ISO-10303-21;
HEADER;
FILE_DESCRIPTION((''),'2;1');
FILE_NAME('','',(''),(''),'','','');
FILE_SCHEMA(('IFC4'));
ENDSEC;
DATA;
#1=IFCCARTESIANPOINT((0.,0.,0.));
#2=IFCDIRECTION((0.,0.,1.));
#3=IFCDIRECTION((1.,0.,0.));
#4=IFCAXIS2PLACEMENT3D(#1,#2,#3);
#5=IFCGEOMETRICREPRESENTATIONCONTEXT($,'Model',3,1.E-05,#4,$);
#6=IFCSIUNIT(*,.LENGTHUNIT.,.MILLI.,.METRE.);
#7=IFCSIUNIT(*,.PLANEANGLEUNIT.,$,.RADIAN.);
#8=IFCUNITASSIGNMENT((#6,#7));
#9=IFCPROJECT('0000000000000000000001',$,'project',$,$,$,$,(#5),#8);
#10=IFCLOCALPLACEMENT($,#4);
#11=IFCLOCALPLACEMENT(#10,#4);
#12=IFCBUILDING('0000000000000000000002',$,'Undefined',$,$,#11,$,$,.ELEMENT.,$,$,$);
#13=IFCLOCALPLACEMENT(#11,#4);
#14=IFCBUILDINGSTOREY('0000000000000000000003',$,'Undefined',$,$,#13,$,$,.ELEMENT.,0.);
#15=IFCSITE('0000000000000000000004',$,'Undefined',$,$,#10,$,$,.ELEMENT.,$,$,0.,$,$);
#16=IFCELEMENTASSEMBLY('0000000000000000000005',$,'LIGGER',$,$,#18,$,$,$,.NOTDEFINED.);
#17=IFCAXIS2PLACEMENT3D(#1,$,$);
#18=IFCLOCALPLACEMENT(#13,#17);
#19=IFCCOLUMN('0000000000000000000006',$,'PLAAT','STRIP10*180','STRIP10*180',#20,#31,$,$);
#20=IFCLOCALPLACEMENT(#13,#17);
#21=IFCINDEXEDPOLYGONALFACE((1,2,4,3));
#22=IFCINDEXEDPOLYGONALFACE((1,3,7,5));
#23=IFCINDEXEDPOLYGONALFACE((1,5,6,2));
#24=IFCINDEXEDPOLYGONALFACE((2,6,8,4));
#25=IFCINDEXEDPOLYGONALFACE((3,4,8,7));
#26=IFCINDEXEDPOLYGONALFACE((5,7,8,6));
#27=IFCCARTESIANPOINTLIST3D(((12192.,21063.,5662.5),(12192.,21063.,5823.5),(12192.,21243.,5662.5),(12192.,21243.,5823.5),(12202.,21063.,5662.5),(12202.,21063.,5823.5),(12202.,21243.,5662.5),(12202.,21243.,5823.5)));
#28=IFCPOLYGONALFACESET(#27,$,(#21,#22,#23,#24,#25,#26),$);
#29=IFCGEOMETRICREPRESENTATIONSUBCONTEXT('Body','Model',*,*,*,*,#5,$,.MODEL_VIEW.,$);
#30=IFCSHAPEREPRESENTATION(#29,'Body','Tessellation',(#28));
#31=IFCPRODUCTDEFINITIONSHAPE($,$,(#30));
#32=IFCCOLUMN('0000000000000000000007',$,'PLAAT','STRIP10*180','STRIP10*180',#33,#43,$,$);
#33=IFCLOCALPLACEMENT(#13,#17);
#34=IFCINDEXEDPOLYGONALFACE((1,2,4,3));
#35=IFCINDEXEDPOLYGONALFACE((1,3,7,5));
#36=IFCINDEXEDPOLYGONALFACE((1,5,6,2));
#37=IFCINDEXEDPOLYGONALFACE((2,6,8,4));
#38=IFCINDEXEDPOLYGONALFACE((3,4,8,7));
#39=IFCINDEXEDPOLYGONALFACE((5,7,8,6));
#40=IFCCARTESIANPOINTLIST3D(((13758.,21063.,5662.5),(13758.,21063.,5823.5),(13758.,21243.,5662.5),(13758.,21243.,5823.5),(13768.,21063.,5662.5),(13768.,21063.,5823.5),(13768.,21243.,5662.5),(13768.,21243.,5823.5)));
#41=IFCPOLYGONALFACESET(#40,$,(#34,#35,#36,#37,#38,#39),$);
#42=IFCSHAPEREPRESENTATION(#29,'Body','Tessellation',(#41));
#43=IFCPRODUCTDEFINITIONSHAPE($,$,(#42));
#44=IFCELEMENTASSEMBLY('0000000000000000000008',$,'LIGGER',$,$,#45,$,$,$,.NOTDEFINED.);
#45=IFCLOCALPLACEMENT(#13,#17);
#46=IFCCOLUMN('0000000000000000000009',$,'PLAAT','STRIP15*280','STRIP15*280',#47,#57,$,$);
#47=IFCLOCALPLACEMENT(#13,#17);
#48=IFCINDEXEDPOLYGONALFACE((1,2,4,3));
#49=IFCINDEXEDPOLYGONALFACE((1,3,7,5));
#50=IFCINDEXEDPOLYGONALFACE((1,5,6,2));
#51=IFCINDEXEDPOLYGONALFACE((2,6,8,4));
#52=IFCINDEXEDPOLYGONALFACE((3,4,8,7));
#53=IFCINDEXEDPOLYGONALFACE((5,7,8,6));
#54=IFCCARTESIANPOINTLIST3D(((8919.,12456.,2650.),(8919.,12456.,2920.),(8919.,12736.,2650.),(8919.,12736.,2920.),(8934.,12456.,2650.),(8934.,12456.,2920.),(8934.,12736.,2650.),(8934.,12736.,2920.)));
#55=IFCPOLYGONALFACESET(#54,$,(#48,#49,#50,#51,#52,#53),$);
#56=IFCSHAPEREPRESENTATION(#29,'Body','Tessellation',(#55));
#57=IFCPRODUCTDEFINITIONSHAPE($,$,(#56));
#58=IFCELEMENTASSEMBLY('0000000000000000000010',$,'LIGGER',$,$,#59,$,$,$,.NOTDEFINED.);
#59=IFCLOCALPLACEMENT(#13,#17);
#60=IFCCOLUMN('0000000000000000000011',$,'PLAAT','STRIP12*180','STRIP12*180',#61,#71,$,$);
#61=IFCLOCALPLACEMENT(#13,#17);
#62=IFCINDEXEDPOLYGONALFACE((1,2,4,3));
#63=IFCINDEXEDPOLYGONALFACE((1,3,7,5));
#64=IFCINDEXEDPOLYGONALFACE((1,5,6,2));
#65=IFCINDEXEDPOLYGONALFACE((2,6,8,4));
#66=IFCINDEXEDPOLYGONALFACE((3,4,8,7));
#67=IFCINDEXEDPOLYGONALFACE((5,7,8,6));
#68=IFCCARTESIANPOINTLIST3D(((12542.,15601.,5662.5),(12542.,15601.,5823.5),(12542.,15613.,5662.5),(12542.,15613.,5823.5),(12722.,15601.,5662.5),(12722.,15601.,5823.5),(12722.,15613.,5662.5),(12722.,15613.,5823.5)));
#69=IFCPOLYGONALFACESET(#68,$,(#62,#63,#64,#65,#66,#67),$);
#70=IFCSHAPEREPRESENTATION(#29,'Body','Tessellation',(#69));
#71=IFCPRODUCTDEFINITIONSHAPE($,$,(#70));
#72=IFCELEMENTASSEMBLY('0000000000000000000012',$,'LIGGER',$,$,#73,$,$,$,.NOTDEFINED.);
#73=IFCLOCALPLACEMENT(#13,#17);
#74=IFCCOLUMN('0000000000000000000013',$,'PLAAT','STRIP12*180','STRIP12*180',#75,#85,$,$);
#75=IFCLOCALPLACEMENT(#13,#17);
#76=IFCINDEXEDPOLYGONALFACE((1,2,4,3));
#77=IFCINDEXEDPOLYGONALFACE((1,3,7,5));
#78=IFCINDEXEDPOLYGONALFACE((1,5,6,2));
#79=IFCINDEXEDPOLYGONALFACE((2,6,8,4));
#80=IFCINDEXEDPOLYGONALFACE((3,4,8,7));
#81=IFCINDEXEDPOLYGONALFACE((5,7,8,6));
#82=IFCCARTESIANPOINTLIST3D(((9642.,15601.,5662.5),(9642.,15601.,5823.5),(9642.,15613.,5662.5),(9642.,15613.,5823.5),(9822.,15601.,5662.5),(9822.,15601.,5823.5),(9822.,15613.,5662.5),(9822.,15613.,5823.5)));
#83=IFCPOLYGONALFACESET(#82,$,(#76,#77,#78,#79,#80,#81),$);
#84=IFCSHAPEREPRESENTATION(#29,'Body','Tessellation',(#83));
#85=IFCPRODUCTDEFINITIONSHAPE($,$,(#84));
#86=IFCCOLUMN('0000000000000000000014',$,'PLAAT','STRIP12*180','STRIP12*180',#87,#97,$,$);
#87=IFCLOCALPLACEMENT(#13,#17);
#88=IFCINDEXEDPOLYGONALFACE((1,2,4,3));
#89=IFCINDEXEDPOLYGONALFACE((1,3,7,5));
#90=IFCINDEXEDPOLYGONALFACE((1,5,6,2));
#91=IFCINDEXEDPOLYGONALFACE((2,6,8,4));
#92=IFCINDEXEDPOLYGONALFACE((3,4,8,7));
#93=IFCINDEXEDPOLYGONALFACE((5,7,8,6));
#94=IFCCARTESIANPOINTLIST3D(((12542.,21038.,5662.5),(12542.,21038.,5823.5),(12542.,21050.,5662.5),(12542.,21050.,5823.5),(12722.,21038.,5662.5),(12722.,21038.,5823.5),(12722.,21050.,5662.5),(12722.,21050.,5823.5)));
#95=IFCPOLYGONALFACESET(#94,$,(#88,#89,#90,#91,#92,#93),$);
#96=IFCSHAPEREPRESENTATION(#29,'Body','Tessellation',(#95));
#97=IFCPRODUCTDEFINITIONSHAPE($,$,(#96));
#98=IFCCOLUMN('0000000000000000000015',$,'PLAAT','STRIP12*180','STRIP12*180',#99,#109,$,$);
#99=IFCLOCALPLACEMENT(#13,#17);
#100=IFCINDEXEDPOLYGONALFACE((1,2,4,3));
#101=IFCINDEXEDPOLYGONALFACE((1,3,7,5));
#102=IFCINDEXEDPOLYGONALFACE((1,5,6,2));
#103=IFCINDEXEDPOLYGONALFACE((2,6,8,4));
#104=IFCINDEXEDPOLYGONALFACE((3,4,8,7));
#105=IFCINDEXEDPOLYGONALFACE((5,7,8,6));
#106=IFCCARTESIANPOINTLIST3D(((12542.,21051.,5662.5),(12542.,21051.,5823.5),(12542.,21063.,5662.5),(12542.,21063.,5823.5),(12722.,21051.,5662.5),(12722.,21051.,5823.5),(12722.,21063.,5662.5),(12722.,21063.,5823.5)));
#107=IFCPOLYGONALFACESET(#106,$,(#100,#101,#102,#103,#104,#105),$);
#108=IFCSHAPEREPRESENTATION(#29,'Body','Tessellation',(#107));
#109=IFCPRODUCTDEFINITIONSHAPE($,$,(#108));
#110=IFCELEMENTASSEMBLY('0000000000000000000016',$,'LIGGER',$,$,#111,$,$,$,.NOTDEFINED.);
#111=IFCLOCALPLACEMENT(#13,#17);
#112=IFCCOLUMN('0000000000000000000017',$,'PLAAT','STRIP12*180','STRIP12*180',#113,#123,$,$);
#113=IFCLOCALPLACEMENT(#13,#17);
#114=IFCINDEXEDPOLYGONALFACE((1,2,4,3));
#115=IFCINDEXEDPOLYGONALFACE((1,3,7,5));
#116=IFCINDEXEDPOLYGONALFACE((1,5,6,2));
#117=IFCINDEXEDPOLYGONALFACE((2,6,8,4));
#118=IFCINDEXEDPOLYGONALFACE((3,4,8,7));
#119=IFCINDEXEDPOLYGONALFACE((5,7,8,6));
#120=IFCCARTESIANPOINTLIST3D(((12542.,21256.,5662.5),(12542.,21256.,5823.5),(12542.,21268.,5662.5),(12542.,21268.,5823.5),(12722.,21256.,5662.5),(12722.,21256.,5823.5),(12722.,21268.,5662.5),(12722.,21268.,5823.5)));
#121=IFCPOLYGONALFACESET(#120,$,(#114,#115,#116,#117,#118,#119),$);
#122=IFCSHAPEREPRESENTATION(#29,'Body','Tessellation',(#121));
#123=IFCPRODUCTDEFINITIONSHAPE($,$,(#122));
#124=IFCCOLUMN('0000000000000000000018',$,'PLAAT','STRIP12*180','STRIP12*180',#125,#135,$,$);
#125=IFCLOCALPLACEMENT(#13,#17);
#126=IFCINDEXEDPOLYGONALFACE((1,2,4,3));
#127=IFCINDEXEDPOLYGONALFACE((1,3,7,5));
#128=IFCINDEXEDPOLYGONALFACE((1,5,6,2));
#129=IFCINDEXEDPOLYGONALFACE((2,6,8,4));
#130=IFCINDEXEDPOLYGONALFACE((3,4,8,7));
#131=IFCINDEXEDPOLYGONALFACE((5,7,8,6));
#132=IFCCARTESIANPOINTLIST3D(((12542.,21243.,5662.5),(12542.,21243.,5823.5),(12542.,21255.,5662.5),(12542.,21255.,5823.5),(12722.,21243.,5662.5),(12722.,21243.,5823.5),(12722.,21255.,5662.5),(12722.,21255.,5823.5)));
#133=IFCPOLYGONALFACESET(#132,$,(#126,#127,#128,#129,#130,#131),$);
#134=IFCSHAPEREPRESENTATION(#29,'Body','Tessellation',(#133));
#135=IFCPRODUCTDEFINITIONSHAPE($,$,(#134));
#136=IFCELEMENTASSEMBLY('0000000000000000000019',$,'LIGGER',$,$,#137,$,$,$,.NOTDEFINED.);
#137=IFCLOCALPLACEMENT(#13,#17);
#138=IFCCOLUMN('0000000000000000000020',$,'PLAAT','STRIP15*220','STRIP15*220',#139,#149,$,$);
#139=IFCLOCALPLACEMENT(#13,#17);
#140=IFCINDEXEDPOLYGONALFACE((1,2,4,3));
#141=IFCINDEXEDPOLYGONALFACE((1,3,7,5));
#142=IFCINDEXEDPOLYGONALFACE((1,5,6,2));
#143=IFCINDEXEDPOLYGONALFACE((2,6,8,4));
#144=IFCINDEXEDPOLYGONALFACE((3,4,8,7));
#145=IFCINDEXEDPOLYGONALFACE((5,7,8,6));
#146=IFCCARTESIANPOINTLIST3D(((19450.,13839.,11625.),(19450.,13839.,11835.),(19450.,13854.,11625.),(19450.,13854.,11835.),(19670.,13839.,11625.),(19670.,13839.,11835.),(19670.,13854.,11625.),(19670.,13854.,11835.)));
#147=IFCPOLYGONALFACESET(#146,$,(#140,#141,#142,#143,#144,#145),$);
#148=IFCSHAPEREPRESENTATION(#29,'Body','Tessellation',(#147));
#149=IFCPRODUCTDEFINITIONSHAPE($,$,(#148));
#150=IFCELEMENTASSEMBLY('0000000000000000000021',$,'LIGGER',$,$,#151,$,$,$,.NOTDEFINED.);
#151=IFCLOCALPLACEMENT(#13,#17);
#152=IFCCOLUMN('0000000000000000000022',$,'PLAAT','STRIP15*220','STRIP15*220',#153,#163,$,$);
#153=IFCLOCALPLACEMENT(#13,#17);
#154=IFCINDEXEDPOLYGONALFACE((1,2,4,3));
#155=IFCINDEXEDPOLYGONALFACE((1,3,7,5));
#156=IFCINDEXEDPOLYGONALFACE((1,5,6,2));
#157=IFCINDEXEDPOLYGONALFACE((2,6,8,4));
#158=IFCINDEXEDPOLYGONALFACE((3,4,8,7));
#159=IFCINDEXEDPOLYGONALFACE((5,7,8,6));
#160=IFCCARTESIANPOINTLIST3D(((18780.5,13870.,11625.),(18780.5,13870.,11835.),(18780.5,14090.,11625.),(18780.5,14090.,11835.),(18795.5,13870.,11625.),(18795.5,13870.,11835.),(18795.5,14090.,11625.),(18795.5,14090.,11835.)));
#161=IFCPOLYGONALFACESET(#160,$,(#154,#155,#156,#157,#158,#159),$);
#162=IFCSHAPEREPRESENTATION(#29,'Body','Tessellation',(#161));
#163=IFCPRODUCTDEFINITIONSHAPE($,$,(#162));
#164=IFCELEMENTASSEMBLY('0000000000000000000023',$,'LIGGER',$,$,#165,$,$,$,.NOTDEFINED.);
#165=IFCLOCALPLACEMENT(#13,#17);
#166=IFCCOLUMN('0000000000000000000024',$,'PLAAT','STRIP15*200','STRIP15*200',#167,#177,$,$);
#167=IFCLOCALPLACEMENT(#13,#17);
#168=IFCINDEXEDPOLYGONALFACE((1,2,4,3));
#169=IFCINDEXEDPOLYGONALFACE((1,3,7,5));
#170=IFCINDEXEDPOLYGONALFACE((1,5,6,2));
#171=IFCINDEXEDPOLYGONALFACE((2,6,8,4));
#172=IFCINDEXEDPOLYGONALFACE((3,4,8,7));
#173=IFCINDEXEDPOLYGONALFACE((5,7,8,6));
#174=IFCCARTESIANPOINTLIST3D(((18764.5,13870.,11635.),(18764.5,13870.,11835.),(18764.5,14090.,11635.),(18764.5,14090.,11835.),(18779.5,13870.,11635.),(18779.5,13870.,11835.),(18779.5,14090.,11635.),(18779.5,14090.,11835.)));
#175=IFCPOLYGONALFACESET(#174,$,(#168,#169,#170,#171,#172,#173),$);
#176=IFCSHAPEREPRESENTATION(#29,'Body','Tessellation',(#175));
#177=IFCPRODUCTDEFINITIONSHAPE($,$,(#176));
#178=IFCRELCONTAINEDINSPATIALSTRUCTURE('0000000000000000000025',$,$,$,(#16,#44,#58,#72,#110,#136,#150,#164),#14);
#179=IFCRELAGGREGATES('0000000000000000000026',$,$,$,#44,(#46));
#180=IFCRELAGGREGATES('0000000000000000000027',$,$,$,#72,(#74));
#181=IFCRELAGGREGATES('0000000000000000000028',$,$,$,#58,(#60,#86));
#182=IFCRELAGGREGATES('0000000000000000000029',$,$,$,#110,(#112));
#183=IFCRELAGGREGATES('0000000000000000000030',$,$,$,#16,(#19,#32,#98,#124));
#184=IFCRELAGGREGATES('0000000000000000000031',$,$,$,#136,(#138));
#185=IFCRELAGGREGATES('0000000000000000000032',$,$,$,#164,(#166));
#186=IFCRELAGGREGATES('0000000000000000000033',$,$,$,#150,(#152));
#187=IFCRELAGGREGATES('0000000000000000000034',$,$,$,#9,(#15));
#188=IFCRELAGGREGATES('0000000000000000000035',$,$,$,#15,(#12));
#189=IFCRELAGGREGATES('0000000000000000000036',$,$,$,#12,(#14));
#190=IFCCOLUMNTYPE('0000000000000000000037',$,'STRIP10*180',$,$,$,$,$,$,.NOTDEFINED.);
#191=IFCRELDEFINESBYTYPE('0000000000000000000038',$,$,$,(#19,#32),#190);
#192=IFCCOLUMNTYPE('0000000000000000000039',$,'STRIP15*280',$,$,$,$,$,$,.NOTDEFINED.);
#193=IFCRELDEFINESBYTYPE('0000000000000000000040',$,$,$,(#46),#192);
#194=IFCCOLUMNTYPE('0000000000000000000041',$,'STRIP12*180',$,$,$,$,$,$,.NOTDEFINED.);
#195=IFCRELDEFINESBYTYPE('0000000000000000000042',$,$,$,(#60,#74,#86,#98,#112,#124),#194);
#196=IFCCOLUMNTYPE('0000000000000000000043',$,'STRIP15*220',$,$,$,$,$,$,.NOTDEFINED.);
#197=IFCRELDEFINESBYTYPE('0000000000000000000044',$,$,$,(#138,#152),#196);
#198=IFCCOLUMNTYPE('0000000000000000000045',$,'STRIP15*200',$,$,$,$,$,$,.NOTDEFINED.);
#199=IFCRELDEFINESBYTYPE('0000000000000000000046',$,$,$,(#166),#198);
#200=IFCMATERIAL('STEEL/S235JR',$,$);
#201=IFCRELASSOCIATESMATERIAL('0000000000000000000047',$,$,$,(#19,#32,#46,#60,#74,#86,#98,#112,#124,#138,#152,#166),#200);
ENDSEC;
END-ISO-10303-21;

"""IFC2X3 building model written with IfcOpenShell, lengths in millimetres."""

from ifc_helpers import new_model, si_unit, frame, origin_with_axes, origin_2d_with_axis, place, context, subcontext, project, spatial, rectangle, extrude, material, type_object, element, aggregate, save


model = new_model("IFC2X3")

# Units and contexts
model_context = context("Model", 3, precision=1e-05, world=origin_with_axes())
body_context = subcontext(model_context, "Body", "Model", "MODEL_VIEW")
ifc_project = project(units=[si_unit("LENGTHUNIT", "METRE", prefix="MILLI"), si_unit("PLANEANGLEUNIT", "RADIAN")], contexts=[model_context])

# Site, building, storey
site_placement = place(None, origin_with_axes())
site = spatial("IfcSite", under=ifc_project, at=site_placement, Name="Undefined", CompositionType="ELEMENT", RefElevation=0.0)
building_placement = place(site_placement, origin_with_axes())
building = spatial("IfcBuilding", under=site, at=building_placement, Name="Undefined", CompositionType="ELEMENT")
storey_placement = place(building_placement, origin_with_axes())
storey = spatial("IfcBuildingStorey", under=building, at=storey_placement, Name="Undefined", CompositionType="ELEMENT", Elevation=0.0)

# Element assembly, columns
assembly_1_placement = place(storey_placement, frame((13295.0, 21153.0, 5743.0), z_axis=(0.0, 0.0, 1.0), x_axis=(-1.0, 0.0, 0.0)))
assembly_1 = element("IfcElementAssembly", 1, at=assembly_1_placement, inside=storey, Name="LIGGER", PredefinedType="NOTDEFINED")
ifc_material = material(Name="STEEL/S235JR")
column_type_1 = type_object("IfcColumnType", Name="STRIP10*180", PredefinedType="NOTDEFINED")
column_1_placement = place(storey_placement, frame((12197.0, 21153.0, 5662.5), z_axis=(0.0, 0.0, 1.0), x_axis=(1.0, 0.0, 0.0)))
column_1 = element("IfcColumn", 2, at=column_1_placement, type_object=column_type_1, material=ifc_material, Name="PLAAT", Description="STRIP10*180", ObjectType="STRIP10*180", context=body_context, shape_type="SweptSolid", body=[
    extrude(rectangle(XDim=10.0, YDim=180.0, at=origin_2d_with_axis()), frame((0.0, 0.0, 161.0), z_axis=(0.0, 0.0, -1.0), x_axis=(1.0, 0.0, 0.0)), (0.0, 0.0, 1.0), 161.0),
])
column_2_placement = place(storey_placement, frame((13763.0, 21153.0, 5662.5), z_axis=(0.0, 0.0, 1.0), x_axis=(1.0, 0.0, 0.0)))
column_2 = element("IfcColumn", 3, at=column_2_placement, type_object=column_type_1, material=ifc_material, Name="PLAAT", Description="STRIP10*180", ObjectType="STRIP10*180", context=body_context, shape_type="SweptSolid", body=[
    extrude(rectangle(XDim=10.0, YDim=180.0, at=origin_2d_with_axis()), frame((0.0, 0.0, 161.0), z_axis=(0.0, 0.0, -1.0), x_axis=(-1.0, 0.0, 0.0)), (0.0, 0.0, 1.0), 161.0),
])

# Element assemblies, columns
assembly_2_placement = place(storey_placement, frame((5727.0, 12596.0, 2785.0), z_axis=(0.0, 0.0, 1.0), x_axis=(1.0, 0.0, 0.0)))
assembly_2 = element("IfcElementAssembly", 4, at=assembly_2_placement, inside=storey, Name="LIGGER", PredefinedType="NOTDEFINED")
column_type_2 = type_object("IfcColumnType", Name="STRIP15*280", PredefinedType="NOTDEFINED")
column_3_placement = place(storey_placement, frame((8926.5, 12596.0, 2650.0), z_axis=(0.0, 0.0, 1.0), x_axis=(1.0, 0.0, 0.0)))
column_3 = element("IfcColumn", 5, at=column_3_placement, type_object=column_type_2, material=ifc_material, Name="PLAAT", Description="STRIP15*280", ObjectType="STRIP15*280", context=body_context, shape_type="SweptSolid", body=[
    extrude(rectangle(XDim=15.0, YDim=280.0, at=origin_2d_with_axis()), frame((0.0, 0.0, 270.0), z_axis=(0.0, 0.0, -1.0), x_axis=(-1.0, 0.0, 0.0)), (0.0, 0.0, 1.0), 270.0),
])
aggregate(assembly_2, [column_3])
assembly_3_placement = place(storey_placement, frame((12632.0, 21063.0, 5743.0), z_axis=(0.0, 0.0, 1.0), x_axis=(0.0, -1.0, 0.0)))
assembly_3 = element("IfcElementAssembly", 6, at=assembly_3_placement, inside=storey, Name="LIGGER", PredefinedType="NOTDEFINED")
column_type_3 = type_object("IfcColumnType", Name="STRIP12*180", PredefinedType="NOTDEFINED")
column_4_placement = place(storey_placement, frame((12632.0, 15607.0, 5662.5), z_axis=(0.0, 0.0, 1.0), x_axis=(1.0, 0.0, 0.0)))
column_4 = element("IfcColumn", 7, at=column_4_placement, type_object=column_type_3, material=ifc_material, Name="PLAAT", Description="STRIP12*180", ObjectType="STRIP12*180", context=body_context, shape_type="SweptSolid", body=[
    extrude(rectangle(XDim=12.0, YDim=180.0, at=origin_2d_with_axis()), frame((0.0, 0.0, 161.0), z_axis=(0.0, 0.0, -1.0), x_axis=(0.0, 1.0, 0.0)), (0.0, 0.0, 1.0), 161.0),
])
assembly_4_placement = place(storey_placement, frame((9732.0, 21875.0, 5743.0), z_axis=(0.0, 0.0, 1.0), x_axis=(0.0, -1.0, 0.0)))
assembly_4 = element("IfcElementAssembly", 8, at=assembly_4_placement, inside=storey, Name="LIGGER", PredefinedType="NOTDEFINED")
column_5_placement = place(storey_placement, frame((9732.0, 15607.0, 5662.5), z_axis=(0.0, 0.0, 1.0), x_axis=(1.0, 0.0, 0.0)))
column_5 = element("IfcColumn", 9, at=column_5_placement, type_object=column_type_3, material=ifc_material, Name="PLAAT", Description="STRIP12*180", ObjectType="STRIP12*180", context=body_context, shape_type="SweptSolid", body=[
    extrude(rectangle(XDim=12.0, YDim=180.0, at=origin_2d_with_axis()), frame((0.0, 0.0, 161.0), z_axis=(0.0, 0.0, -1.0), x_axis=(0.0, 1.0, 0.0)), (0.0, 0.0, 1.0), 161.0),
])
aggregate(assembly_4, [column_5])

# Columns
column_6_placement = place(storey_placement, frame((12632.0, 21044.0, 5662.5), z_axis=(0.0, 0.0, 1.0), x_axis=(1.0, 0.0, 0.0)))
column_6 = element("IfcColumn", 10, at=column_6_placement, type_object=column_type_3, material=ifc_material, Name="PLAAT", Description="STRIP12*180", ObjectType="STRIP12*180", context=body_context, shape_type="SweptSolid", body=[
    extrude(rectangle(XDim=12.0, YDim=180.0, at=origin_2d_with_axis()), frame((0.0, 0.0, 161.0), z_axis=(0.0, 0.0, -1.0), x_axis=(0.0, -1.0, 0.0)), (0.0, 0.0, 1.0), 161.0),
])
aggregate(assembly_3, [column_4, column_6])
column_7_placement = place(storey_placement, frame((12632.0, 21057.0, 5662.5), z_axis=(0.0, 0.0, 1.0), x_axis=(1.0, 0.0, 0.0)))
column_7 = element("IfcColumn", 11, at=column_7_placement, type_object=column_type_3, material=ifc_material, Name="PLAAT", Description="STRIP12*180", ObjectType="STRIP12*180", context=body_context, shape_type="SweptSolid", body=[
    extrude(rectangle(XDim=12.0, YDim=180.0, at=origin_2d_with_axis()), frame((0.0, 0.0, 161.0), z_axis=(0.0, 0.0, -1.0), x_axis=(0.0, -1.0, 0.0)), (0.0, 0.0, 1.0), 161.0),
])

# Element assembly, column
assembly_5_placement = place(storey_placement, frame((12632.0, 21875.0, 5743.0), z_axis=(0.0, 0.0, 1.0), x_axis=(0.0, -1.0, 0.0)))
assembly_5 = element("IfcElementAssembly", 12, at=assembly_5_placement, inside=storey, Name="LIGGER", PredefinedType="NOTDEFINED")
column_8_placement = place(storey_placement, frame((12632.0, 21262.0, 5662.5), z_axis=(0.0, 0.0, 1.0), x_axis=(1.0, 0.0, 0.0)))
column_8 = element("IfcColumn", 13, at=column_8_placement, type_object=column_type_3, material=ifc_material, Name="PLAAT", Description="STRIP12*180", ObjectType="STRIP12*180", context=body_context, shape_type="SweptSolid", body=[
    extrude(rectangle(XDim=12.0, YDim=180.0, at=origin_2d_with_axis()), frame((0.0, 0.0, 161.0), z_axis=(0.0, 0.0, -1.0), x_axis=(0.0, 1.0, 0.0)), (0.0, 0.0, 1.0), 161.0),
])
aggregate(assembly_5, [column_8])

# Column
column_9_placement = place(storey_placement, frame((12632.0, 21249.0, 5662.5), z_axis=(0.0, 0.0, 1.0), x_axis=(1.0, 0.0, 0.0)))
column_9 = element("IfcColumn", 14, at=column_9_placement, type_object=column_type_3, material=ifc_material, Name="PLAAT", Description="STRIP12*180", ObjectType="STRIP12*180", context=body_context, shape_type="SweptSolid", body=[
    extrude(rectangle(XDim=12.0, YDim=180.0, at=origin_2d_with_axis()), frame((0.0, 0.0, 161.0), z_axis=(0.0, 0.0, -1.0), x_axis=(0.0, 1.0, 0.0)), (0.0, 0.0, 1.0), 161.0),
])
aggregate(assembly_1, [column_1, column_2, column_7, column_9])

# Element assembly, column
assembly_6_placement = place(storey_placement, frame((19560.0, 13870.0, 11730.0), z_axis=(0.0, 0.0, 1.0), x_axis=(0.0, -1.0, 0.0)))
assembly_6 = element("IfcElementAssembly", 15, at=assembly_6_placement, inside=storey, Name="LIGGER", PredefinedType="NOTDEFINED")
column_type_4 = type_object("IfcColumnType", Name="STRIP15*220", PredefinedType="NOTDEFINED")
column_10_placement = place(storey_placement, frame((19560.0, 13846.5, 11625.0), z_axis=(0.0, 0.0, 1.0), x_axis=(1.0, 0.0, 0.0)))
column_10 = element("IfcColumn", 16, at=column_10_placement, type_object=column_type_4, material=ifc_material, Name="PLAAT", Description="STRIP15*220", ObjectType="STRIP15*220", context=body_context, shape_type="SweptSolid", body=[
    extrude(rectangle(XDim=15.0, YDim=220.0, at=origin_2d_with_axis()), frame((0.0, 0.0, 210.0), z_axis=(0.0, 0.0, -1.0), x_axis=(0.0, -1.0, 0.0)), (0.0, 0.0, 1.0), 210.0),
])
aggregate(assembly_6, [column_10])

# Element assembly, column
assembly_7_placement = place(storey_placement, frame((19599.0, 13980.0, 11793.5), z_axis=(0.906308, 0.0, 0.422618), x_axis=(0.422618, 0.0, -0.906308)))
assembly_7 = element("IfcElementAssembly", 17, at=assembly_7_placement, inside=storey, Name="LIGGER", PredefinedType="NOTDEFINED")
column_11_placement = place(storey_placement, frame((18788.0, 13980.0, 11625.0), z_axis=(0.0, 0.0, 1.0), x_axis=(1.0, 0.0, 0.0)))
column_11 = element("IfcColumn", 18, at=column_11_placement, type_object=column_type_4, material=ifc_material, Name="PLAAT", Description="STRIP15*220", ObjectType="STRIP15*220", context=body_context, shape_type="SweptSolid", body=[
    extrude(rectangle(XDim=15.0, YDim=220.0, at=origin_2d_with_axis()), frame((0.0, 0.0, 210.0), z_axis=(0.0, 0.0, -1.0), x_axis=(-1.0, 0.0, 0.0)), (0.0, 0.0, 1.0), 210.0),
])

# Element assembly, column
assembly_8_placement = place(storey_placement, frame((7150.0, 13980.0, 11735.0), z_axis=(0.0, 0.0, 1.0), x_axis=(1.0, 0.0, 0.0)))
assembly_8 = element("IfcElementAssembly", 19, at=assembly_8_placement, inside=storey, Name="LIGGER", PredefinedType="NOTDEFINED")
column_type_5 = type_object("IfcColumnType", Name="STRIP15*200", PredefinedType="NOTDEFINED")
column_12_placement = place(storey_placement, frame((18772.0, 13980.0, 11635.0), z_axis=(0.0, 0.0, 1.0), x_axis=(1.0, 0.0, 0.0)))
column_12 = element("IfcColumn", 20, at=column_12_placement, type_object=column_type_5, material=ifc_material, Name="PLAAT", Description="STRIP15*200", ObjectType="STRIP15*200", context=body_context, shape_type="SweptSolid", body=[
    extrude(rectangle(XDim=15.0, YDim=220.0, at=origin_2d_with_axis()), frame((0.0, 0.0, 200.0), z_axis=(0.0, 0.0, -1.0), x_axis=(-1.0, 0.0, 0.0)), (0.0, 0.0, 1.0), 200.0),
])
aggregate(assembly_8, [column_12])

aggregate(assembly_7, [column_11])

save(model, "model.ifc")
